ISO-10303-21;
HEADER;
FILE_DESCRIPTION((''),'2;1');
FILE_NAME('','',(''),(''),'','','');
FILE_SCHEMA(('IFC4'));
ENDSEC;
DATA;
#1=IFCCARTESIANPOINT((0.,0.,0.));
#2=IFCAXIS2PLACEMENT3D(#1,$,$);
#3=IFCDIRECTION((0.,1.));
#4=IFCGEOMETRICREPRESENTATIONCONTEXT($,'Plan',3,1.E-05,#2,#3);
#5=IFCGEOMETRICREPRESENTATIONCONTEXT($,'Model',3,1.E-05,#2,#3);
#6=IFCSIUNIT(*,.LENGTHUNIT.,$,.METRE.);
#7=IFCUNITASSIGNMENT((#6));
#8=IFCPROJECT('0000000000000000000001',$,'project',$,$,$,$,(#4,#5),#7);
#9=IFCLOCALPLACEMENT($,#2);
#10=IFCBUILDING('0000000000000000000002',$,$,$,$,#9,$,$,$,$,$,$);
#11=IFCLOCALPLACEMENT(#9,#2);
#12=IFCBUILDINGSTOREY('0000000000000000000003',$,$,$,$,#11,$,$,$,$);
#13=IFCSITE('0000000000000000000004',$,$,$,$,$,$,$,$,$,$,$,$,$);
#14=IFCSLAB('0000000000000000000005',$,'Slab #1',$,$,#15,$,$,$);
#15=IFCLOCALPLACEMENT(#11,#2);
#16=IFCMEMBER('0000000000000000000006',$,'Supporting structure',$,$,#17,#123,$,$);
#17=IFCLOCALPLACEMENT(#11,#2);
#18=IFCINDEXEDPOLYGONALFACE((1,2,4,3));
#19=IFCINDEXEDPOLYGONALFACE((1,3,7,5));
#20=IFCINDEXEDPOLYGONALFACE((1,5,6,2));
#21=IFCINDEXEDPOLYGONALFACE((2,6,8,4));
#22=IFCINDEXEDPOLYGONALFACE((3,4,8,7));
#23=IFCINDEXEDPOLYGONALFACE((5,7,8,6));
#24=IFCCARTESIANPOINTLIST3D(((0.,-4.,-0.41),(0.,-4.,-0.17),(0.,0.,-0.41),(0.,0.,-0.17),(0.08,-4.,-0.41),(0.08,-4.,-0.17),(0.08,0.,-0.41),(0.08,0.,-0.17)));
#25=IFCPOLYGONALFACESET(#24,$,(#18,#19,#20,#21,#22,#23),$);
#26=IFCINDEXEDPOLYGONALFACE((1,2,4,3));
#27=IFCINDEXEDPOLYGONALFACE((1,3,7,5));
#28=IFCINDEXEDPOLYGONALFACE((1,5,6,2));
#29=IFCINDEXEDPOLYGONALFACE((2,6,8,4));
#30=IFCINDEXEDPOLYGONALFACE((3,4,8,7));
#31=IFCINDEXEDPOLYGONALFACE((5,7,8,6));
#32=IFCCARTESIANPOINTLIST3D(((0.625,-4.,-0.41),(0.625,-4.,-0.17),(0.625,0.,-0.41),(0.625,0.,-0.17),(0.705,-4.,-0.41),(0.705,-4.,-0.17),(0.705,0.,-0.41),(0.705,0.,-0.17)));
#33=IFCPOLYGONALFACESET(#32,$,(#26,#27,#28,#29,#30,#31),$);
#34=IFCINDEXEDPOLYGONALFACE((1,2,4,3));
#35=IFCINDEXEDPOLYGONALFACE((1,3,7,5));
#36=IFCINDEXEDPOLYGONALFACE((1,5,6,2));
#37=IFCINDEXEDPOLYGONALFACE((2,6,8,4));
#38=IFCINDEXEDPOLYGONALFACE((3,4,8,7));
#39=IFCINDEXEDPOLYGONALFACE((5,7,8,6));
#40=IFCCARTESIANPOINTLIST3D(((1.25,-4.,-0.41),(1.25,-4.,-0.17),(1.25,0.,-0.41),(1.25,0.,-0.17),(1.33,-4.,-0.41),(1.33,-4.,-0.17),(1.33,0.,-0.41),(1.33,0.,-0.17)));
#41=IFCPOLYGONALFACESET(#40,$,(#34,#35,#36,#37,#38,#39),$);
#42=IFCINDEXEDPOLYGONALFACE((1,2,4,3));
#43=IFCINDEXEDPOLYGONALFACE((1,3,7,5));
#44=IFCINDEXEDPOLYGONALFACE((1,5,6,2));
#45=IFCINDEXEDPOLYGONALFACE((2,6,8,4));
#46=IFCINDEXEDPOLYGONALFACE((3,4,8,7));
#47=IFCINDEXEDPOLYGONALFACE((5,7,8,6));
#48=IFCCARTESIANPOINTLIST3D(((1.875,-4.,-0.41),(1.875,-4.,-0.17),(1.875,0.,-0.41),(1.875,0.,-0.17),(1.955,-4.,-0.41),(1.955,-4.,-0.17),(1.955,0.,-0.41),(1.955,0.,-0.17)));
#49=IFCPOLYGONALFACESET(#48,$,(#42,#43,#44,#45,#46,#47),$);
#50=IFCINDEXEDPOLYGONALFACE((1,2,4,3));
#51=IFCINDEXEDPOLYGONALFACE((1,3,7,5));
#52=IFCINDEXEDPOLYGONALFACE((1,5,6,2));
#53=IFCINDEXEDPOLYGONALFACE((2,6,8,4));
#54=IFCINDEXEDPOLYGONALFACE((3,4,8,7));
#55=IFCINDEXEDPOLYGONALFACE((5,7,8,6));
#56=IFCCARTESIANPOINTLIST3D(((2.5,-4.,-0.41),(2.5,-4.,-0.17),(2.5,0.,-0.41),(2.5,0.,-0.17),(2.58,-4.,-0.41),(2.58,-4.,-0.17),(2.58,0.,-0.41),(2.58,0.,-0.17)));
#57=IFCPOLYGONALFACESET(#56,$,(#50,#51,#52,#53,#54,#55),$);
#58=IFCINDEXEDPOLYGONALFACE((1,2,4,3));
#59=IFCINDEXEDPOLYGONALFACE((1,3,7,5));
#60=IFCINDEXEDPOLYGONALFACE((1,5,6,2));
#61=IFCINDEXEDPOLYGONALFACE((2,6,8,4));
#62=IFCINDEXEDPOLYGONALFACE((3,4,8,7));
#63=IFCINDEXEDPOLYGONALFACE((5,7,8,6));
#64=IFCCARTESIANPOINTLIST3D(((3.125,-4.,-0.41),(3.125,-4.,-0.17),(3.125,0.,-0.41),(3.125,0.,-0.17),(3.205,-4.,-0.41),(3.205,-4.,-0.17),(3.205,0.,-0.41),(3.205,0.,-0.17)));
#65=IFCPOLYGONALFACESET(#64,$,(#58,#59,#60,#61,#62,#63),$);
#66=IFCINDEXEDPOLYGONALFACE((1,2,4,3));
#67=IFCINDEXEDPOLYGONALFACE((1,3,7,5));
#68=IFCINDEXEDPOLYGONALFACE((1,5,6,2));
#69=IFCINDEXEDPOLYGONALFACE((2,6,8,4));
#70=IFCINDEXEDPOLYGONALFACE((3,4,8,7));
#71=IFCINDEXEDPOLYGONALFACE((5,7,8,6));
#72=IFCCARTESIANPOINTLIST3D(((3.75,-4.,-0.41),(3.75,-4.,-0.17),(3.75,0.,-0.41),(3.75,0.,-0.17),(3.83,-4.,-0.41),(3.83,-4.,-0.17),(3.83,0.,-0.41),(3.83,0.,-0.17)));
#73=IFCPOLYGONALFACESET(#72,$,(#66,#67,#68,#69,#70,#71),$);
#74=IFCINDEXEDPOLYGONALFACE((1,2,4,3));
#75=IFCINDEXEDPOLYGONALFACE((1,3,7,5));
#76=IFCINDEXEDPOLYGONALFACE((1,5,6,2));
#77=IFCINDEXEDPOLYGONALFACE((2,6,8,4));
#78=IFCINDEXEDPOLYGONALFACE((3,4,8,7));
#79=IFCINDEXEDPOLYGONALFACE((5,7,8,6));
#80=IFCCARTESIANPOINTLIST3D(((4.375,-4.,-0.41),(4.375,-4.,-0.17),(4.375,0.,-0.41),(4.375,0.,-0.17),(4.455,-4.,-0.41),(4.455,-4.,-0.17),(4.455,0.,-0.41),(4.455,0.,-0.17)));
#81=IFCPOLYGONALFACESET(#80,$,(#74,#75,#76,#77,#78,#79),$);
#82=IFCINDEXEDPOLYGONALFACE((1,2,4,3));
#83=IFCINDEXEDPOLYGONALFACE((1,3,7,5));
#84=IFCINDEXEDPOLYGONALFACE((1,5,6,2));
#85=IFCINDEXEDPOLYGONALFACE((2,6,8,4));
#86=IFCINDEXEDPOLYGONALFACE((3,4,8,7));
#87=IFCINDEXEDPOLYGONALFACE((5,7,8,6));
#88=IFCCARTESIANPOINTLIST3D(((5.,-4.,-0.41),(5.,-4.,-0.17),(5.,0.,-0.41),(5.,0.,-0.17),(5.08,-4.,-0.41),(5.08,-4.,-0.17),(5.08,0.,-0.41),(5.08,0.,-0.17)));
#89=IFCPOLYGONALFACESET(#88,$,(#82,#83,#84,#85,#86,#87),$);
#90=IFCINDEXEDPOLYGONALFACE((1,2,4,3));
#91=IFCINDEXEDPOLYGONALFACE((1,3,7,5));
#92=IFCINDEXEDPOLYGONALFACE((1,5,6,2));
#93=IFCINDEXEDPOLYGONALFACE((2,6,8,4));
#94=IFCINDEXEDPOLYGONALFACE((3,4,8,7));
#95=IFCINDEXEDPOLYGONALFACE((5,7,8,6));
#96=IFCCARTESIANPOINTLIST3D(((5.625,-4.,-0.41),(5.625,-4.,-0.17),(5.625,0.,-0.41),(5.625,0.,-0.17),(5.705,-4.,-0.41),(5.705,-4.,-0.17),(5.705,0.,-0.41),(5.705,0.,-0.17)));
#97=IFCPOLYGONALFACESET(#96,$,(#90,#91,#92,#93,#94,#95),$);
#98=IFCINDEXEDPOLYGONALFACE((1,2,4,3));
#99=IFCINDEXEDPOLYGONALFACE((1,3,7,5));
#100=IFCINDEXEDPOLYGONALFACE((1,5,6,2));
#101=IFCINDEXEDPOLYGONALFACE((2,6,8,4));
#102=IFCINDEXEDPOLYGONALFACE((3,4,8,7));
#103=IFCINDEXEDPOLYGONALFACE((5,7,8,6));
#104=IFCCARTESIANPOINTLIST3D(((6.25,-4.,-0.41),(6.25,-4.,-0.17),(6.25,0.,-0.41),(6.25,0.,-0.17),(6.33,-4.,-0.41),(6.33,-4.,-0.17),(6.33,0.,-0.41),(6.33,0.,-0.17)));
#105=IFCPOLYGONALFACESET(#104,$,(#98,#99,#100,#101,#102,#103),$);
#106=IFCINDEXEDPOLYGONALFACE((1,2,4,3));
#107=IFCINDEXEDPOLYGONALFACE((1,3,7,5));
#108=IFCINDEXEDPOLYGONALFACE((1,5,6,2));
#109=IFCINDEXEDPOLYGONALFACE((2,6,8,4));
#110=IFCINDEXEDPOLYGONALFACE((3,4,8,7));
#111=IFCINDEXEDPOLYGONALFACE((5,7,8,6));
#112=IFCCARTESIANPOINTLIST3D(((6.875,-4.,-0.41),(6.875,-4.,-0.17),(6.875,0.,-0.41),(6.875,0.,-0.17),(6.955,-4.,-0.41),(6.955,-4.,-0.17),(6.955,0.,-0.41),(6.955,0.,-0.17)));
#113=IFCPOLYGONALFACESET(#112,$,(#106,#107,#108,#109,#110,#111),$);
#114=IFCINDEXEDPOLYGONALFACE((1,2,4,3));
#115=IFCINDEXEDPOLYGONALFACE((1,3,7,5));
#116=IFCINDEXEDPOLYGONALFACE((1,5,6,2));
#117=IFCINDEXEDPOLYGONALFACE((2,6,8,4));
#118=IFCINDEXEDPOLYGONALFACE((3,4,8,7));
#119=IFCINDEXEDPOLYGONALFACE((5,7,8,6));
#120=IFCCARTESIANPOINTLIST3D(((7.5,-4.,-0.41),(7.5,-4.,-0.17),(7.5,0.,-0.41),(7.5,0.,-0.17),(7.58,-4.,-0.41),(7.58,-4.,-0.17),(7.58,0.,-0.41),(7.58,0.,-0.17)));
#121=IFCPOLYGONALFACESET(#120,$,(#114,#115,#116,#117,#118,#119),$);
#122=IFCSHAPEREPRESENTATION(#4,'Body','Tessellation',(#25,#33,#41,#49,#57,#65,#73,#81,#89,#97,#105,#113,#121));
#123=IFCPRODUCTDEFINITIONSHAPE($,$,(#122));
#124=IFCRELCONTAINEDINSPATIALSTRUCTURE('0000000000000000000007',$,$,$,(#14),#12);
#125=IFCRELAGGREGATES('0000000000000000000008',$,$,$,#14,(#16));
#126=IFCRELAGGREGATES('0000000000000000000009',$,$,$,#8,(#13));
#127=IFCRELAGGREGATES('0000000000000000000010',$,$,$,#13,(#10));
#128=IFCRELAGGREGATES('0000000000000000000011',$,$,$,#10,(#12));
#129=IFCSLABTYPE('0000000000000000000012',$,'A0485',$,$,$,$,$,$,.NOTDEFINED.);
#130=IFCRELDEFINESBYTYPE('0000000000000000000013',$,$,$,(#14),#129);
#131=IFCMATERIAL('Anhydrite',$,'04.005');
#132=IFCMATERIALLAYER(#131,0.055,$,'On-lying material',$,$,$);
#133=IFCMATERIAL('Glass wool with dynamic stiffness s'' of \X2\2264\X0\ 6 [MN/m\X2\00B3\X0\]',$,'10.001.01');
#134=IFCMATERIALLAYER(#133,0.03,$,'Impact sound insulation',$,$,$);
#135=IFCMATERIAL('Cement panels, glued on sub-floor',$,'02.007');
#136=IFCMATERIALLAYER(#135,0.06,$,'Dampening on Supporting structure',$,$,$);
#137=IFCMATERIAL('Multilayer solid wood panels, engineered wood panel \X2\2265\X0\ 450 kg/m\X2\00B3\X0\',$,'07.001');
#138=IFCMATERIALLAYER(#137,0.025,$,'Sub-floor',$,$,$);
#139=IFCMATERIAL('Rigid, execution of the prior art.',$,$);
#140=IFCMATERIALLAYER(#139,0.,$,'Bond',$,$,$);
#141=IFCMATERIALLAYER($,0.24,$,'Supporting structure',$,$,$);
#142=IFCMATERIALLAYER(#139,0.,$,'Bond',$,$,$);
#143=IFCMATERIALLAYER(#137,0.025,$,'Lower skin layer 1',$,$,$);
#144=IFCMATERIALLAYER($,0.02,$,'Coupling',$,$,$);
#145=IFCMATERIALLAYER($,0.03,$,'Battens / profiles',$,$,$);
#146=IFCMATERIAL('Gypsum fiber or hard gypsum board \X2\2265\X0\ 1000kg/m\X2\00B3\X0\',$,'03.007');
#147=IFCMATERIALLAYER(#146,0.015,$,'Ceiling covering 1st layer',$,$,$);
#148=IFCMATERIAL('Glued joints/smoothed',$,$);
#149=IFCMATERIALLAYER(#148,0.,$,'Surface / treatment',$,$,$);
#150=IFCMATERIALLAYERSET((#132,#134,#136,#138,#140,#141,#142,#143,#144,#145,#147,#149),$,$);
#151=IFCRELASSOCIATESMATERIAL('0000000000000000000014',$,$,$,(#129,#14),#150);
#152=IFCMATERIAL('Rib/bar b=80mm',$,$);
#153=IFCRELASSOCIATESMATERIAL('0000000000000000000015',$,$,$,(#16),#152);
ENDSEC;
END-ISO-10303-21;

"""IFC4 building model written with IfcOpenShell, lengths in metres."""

from ifc_helpers import new_model, si_unit, direction, frame, frame_2d, origin, place, context, project, spatial, rectangle, extrude, material, layer, layer_set, type_object, element, aggregate, save


model = new_model("IFC4")

# Units and contexts
plan_context = context("Plan", 3, precision=1e-05, world=origin(), true_north=direction((0.0, 1.0)))
model_context = context("Model", 3, precision=1e-05, world=origin(), true_north=direction((0.0, 1.0)))
ifc_project = project(units=[si_unit("LENGTHUNIT", "METRE")], contexts=[plan_context, model_context])

# Site, building, storey
site = spatial("IfcSite", under=ifc_project)
building_placement = place(None, origin())
building = spatial("IfcBuilding", under=site, at=building_placement)
storey_placement = place(building_placement, origin())
storey = spatial("IfcBuildingStorey", under=building, at=storey_placement)

# Slab, member
ifc_material_1 = material(Name="Anhydrite", Category="04.005")
ifc_layer_1 = layer(ifc_material_1, 0.055, Name="On-lying material")
ifc_material_2 = material(Name="Glass wool with dynamic stiffness s' of ≤ 6 [MN/m³]", Category="10.001.01")
ifc_layer_2 = layer(ifc_material_2, 0.03, Name="Impact sound insulation")
ifc_material_3 = material(Name="Cement panels, glued on sub-floor", Category="02.007")
ifc_layer_3 = layer(ifc_material_3, 0.06, Name="Dampening on Supporting structure")
ifc_material_4 = material(Name="Multilayer solid wood panels, engineered wood panel ≥ 450 kg/m³", Category="07.001")
ifc_layer_4 = layer(ifc_material_4, 0.025, Name="Sub-floor")
ifc_material_5 = material(Name="Rigid, execution of the prior art.")
ifc_layer_5 = layer(ifc_material_5, 0.0, Name="Bond")
ifc_layer_6 = layer(None, 0.24, Name="Supporting structure")
ifc_layer_7 = layer(ifc_material_5, 0.0, Name="Bond")
ifc_layer_8 = layer(ifc_material_4, 0.025, Name="Lower skin layer 1")
ifc_layer_9 = layer(None, 0.02, Name="Coupling")
ifc_layer_10 = layer(None, 0.03, Name="Battens / profiles")
ifc_material_6 = material(Name="Gypsum fiber or hard gypsum board ≥ 1000kg/m³", Category="03.007")
ifc_layer_11 = layer(ifc_material_6, 0.015, Name="Ceiling covering 1st layer")
ifc_material_7 = material(Name="Glued joints/smoothed")
ifc_layer_12 = layer(ifc_material_7, 0.0, Name="Surface / treatment")
ifc_layer_set = layer_set([ifc_layer_1, ifc_layer_2, ifc_layer_3, ifc_layer_4, ifc_layer_5, ifc_layer_6, ifc_layer_7, ifc_layer_8, ifc_layer_9, ifc_layer_10, ifc_layer_11, ifc_layer_12])
slab_type = type_object("IfcSlabType", Name="A0485", PredefinedType="NOTDEFINED", material=ifc_layer_set)
slab_placement = place(None, frame((0.0, 0.0, 0.0), z_axis=(0.0, 0.0, -1.0), x_axis=(1.0, 0.0, 0.0)))
slab = element("IfcSlab", 1, at=slab_placement, inside=storey, type_object=slab_type, material=ifc_layer_set, Name="Slab #1")
ifc_material_8 = material(Name="Rib/bar b=80mm")
member_1_placement = place(slab_placement, origin())
member_1 = element("IfcMember", 2, at=member_1_placement, material=ifc_material_8, Name="Supporting structure", context=plan_context, shape_type="SweptSolid", body=[
    extrude(rectangle(XDim=0.08, YDim=0.24, at=frame_2d((0.04, 0.12), x_axis=(1.0, 0.0))), frame((0.0, 4.0, 0.17), z_axis=(0.0, -1.0, 0.0), x_axis=(1.0, 0.0, 0.0)), (0.0, 0.0, 1.0), 4.0),
    extrude(rectangle(XDim=0.08, YDim=0.24, at=frame_2d((0.04, 0.12), x_axis=(1.0, 0.0))), frame((0.625, 4.0, 0.17), z_axis=(0.0, -1.0, 0.0), x_axis=(1.0, 0.0, 0.0)), (0.0, 0.0, 1.0), 4.0),
    extrude(rectangle(XDim=0.08, YDim=0.24, at=frame_2d((0.04, 0.12), x_axis=(1.0, 0.0))), frame((1.25, 4.0, 0.17), z_axis=(0.0, -1.0, 0.0), x_axis=(1.0, 0.0, 0.0)), (0.0, 0.0, 1.0), 4.0),
    extrude(rectangle(XDim=0.08, YDim=0.24, at=frame_2d((0.04, 0.12), x_axis=(1.0, 0.0))), frame((1.875, 4.0, 0.17), z_axis=(0.0, -1.0, 0.0), x_axis=(1.0, 0.0, 0.0)), (0.0, 0.0, 1.0), 4.0),
    extrude(rectangle(XDim=0.08, YDim=0.24, at=frame_2d((0.04, 0.12), x_axis=(1.0, 0.0))), frame((2.5, 4.0, 0.17), z_axis=(0.0, -1.0, 0.0), x_axis=(1.0, 0.0, 0.0)), (0.0, 0.0, 1.0), 4.0),
    extrude(rectangle(XDim=0.08, YDim=0.24, at=frame_2d((0.04, 0.12), x_axis=(1.0, 0.0))), frame((3.125, 4.0, 0.17), z_axis=(0.0, -1.0, 0.0), x_axis=(1.0, 0.0, 0.0)), (0.0, 0.0, 1.0), 4.0),
    extrude(rectangle(XDim=0.08, YDim=0.24, at=frame_2d((0.04, 0.12), x_axis=(1.0, 0.0))), frame((3.75, 4.0, 0.17), z_axis=(0.0, -1.0, 0.0), x_axis=(1.0, 0.0, 0.0)), (0.0, 0.0, 1.0), 4.0),
    extrude(rectangle(XDim=0.08, YDim=0.24, at=frame_2d((0.04, 0.12), x_axis=(1.0, 0.0))), frame((4.375, 4.0, 0.17), z_axis=(0.0, -1.0, 0.0), x_axis=(1.0, 0.0, 0.0)), (0.0, 0.0, 1.0), 4.0),
    extrude(rectangle(XDim=0.08, YDim=0.24, at=frame_2d((0.04, 0.12), x_axis=(1.0, 0.0))), frame((5.0, 4.0, 0.17), z_axis=(0.0, -1.0, 0.0), x_axis=(1.0, 0.0, 0.0)), (0.0, 0.0, 1.0), 4.0),
    extrude(rectangle(XDim=0.08, YDim=0.24, at=frame_2d((0.04, 0.12), x_axis=(1.0, 0.0))), frame((5.625, 4.0, 0.17), z_axis=(0.0, -1.0, 0.0), x_axis=(1.0, 0.0, 0.0)), (0.0, 0.0, 1.0), 4.0),
    extrude(rectangle(XDim=0.08, YDim=0.24, at=frame_2d((0.04, 0.12), x_axis=(1.0, 0.0))), frame((6.25, 4.0, 0.17), z_axis=(0.0, -1.0, 0.0), x_axis=(1.0, 0.0, 0.0)), (0.0, 0.0, 1.0), 4.0),
    extrude(rectangle(XDim=0.08, YDim=0.24, at=frame_2d((0.04, 0.12), x_axis=(1.0, 0.0))), frame((6.875, 4.0, 0.17), z_axis=(0.0, -1.0, 0.0), x_axis=(1.0, 0.0, 0.0)), (0.0, 0.0, 1.0), 4.0),
    extrude(rectangle(XDim=0.08, YDim=0.24, at=frame_2d((0.04, 0.12), x_axis=(1.0, 0.0))), frame((7.5, 4.0, 0.17), z_axis=(0.0, -1.0, 0.0), x_axis=(1.0, 0.0, 0.0)), (0.0, 0.0, 1.0), 4.0),
])
aggregate(slab, [member_1])

save(model, "model.ifc")
